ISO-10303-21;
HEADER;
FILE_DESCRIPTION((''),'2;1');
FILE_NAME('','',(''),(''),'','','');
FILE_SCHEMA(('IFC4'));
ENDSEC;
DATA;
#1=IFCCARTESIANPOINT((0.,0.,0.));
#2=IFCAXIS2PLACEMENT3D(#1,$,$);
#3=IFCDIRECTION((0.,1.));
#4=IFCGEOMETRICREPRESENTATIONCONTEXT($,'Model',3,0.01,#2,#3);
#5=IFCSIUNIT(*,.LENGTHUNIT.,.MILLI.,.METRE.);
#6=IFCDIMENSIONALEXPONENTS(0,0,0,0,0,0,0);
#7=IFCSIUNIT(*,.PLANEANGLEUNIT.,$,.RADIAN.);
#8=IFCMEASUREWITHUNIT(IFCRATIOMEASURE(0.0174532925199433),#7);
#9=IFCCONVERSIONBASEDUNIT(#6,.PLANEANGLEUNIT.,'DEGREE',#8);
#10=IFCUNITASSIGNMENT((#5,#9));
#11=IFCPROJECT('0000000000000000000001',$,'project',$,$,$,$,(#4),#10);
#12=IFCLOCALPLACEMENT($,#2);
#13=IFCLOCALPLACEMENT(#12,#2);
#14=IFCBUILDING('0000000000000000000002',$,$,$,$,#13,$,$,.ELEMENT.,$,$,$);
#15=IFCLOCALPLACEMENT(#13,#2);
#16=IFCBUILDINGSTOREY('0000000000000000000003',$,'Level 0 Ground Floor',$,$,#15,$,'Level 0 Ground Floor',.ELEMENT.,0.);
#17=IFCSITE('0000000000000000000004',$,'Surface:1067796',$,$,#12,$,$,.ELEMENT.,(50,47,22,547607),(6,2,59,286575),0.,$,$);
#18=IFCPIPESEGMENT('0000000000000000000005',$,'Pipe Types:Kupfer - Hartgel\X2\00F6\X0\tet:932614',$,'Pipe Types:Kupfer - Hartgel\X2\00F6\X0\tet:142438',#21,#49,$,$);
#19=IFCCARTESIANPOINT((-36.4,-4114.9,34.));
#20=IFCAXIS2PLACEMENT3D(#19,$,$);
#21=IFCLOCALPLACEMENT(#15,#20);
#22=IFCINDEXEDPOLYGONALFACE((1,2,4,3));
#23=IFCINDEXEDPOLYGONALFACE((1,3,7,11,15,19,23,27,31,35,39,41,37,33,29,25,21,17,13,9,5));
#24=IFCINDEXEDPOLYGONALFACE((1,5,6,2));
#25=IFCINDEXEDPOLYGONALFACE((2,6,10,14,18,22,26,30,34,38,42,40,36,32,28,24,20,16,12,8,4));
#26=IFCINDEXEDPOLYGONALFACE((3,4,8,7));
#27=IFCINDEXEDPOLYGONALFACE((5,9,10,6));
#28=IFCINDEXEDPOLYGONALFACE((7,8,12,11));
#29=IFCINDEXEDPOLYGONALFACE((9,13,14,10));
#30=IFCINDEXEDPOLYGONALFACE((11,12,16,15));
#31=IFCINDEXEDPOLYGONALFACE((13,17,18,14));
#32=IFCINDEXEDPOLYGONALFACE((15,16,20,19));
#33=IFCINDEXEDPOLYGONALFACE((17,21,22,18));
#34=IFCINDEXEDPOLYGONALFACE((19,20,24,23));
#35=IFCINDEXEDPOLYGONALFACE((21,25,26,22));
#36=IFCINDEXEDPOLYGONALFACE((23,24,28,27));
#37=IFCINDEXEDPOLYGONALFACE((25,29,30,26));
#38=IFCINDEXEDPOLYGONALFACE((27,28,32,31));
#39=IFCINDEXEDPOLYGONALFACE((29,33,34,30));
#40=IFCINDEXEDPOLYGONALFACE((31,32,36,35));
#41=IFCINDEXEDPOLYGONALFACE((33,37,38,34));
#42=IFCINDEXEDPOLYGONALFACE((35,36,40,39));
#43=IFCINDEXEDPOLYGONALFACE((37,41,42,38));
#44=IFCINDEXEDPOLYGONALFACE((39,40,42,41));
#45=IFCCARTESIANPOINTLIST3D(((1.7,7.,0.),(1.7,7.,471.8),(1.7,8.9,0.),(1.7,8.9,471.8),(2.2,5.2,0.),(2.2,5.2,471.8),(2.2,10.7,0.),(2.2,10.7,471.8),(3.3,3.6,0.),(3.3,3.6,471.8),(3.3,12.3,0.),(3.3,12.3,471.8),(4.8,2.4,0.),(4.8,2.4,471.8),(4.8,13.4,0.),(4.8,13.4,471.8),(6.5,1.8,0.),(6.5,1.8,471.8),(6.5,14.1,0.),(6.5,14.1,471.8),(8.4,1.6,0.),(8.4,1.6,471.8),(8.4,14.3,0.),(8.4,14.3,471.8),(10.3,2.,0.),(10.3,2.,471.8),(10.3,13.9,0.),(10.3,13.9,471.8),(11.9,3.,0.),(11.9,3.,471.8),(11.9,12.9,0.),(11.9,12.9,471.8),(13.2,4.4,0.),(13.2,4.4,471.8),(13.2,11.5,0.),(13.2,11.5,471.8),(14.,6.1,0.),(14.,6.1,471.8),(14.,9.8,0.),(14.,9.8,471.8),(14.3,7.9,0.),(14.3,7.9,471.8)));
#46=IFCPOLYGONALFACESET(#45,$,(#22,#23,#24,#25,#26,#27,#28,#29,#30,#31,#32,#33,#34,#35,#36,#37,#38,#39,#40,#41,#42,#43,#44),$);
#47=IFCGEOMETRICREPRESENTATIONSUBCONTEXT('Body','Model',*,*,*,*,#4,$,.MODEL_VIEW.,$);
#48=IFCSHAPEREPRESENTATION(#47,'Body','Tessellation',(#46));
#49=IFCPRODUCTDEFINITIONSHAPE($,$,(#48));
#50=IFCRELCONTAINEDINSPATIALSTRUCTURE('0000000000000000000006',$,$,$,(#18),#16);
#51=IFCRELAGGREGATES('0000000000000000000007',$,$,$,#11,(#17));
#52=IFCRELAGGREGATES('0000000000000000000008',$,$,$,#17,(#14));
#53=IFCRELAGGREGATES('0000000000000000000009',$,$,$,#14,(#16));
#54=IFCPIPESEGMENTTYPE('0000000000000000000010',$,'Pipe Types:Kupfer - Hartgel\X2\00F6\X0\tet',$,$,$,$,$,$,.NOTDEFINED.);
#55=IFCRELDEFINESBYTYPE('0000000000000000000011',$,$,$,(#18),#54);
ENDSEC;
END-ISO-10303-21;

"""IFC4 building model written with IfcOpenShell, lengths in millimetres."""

from ifc_helpers import new_model, entity, si_unit, converted_unit, direction, frame, frame_2d, origin, place, context, subcontext, project, spatial, circle, extrude, type_object, element, save


model = new_model("IFC4")

# Units and contexts
model_context = context("Model", 3, precision=0.01, world=origin(), true_north=direction((0.0, 1.0)))
body_context = subcontext(model_context, "Body", "Model", "MODEL_VIEW")
ifc_project = project(units=[si_unit("LENGTHUNIT", "METRE", prefix="MILLI"), converted_unit("PLANEANGLEUNIT", "DEGREE", entity("IfcRatioMeasure", 0.0174532925199433), si_unit("PLANEANGLEUNIT", "RADIAN"), dimensions=[0, 0, 0, 0, 0, 0, 0])], contexts=[model_context])

# Site, building, storey
site_placement = place(None, origin())
site = spatial("IfcSite", under=ifc_project, at=site_placement, Name="Surface:1067796", CompositionType="ELEMENT", RefLatitude=(50, 47, 22, 547607), RefLongitude=(6, 2, 59, 286575), RefElevation=0.0)
building_placement = place(site_placement, origin())
building = spatial("IfcBuilding", under=site, at=building_placement, CompositionType="ELEMENT")
storey_placement = place(building_placement, origin())
storey = spatial("IfcBuildingStorey", under=building, at=storey_placement, Name="Level 0 Ground Floor", LongName="Level 0 Ground Floor", CompositionType="ELEMENT", Elevation=0.0)

# Pipe segment
pipe_segment_type_1 = type_object("IfcPipeSegmentType", Name="Pipe Types:Kupfer - Hartgelötet", PredefinedType="NOTDEFINED")
pipe_segment_1_placement = place(storey_placement, frame((-36.4, -4114.9, 34.0)))
element("IfcPipeSegment", 1, at=pipe_segment_1_placement, inside=storey, type_object=pipe_segment_type_1, Name="Pipe Types:Kupfer - Hartgelötet:932614", ObjectType="Pipe Types:Kupfer - Hartgelötet:142438", context=body_context, shape_type="SweptSolid", body=[
    extrude(circle(Radius=6.3, at=frame_2d((0.0, 0.0), x_axis=(1.0, 0.0))), frame((7.9, 7.9, 0.0)), (0.0, 0.0, 1.0), 471.8),
])

save(model, "model.ifc")
